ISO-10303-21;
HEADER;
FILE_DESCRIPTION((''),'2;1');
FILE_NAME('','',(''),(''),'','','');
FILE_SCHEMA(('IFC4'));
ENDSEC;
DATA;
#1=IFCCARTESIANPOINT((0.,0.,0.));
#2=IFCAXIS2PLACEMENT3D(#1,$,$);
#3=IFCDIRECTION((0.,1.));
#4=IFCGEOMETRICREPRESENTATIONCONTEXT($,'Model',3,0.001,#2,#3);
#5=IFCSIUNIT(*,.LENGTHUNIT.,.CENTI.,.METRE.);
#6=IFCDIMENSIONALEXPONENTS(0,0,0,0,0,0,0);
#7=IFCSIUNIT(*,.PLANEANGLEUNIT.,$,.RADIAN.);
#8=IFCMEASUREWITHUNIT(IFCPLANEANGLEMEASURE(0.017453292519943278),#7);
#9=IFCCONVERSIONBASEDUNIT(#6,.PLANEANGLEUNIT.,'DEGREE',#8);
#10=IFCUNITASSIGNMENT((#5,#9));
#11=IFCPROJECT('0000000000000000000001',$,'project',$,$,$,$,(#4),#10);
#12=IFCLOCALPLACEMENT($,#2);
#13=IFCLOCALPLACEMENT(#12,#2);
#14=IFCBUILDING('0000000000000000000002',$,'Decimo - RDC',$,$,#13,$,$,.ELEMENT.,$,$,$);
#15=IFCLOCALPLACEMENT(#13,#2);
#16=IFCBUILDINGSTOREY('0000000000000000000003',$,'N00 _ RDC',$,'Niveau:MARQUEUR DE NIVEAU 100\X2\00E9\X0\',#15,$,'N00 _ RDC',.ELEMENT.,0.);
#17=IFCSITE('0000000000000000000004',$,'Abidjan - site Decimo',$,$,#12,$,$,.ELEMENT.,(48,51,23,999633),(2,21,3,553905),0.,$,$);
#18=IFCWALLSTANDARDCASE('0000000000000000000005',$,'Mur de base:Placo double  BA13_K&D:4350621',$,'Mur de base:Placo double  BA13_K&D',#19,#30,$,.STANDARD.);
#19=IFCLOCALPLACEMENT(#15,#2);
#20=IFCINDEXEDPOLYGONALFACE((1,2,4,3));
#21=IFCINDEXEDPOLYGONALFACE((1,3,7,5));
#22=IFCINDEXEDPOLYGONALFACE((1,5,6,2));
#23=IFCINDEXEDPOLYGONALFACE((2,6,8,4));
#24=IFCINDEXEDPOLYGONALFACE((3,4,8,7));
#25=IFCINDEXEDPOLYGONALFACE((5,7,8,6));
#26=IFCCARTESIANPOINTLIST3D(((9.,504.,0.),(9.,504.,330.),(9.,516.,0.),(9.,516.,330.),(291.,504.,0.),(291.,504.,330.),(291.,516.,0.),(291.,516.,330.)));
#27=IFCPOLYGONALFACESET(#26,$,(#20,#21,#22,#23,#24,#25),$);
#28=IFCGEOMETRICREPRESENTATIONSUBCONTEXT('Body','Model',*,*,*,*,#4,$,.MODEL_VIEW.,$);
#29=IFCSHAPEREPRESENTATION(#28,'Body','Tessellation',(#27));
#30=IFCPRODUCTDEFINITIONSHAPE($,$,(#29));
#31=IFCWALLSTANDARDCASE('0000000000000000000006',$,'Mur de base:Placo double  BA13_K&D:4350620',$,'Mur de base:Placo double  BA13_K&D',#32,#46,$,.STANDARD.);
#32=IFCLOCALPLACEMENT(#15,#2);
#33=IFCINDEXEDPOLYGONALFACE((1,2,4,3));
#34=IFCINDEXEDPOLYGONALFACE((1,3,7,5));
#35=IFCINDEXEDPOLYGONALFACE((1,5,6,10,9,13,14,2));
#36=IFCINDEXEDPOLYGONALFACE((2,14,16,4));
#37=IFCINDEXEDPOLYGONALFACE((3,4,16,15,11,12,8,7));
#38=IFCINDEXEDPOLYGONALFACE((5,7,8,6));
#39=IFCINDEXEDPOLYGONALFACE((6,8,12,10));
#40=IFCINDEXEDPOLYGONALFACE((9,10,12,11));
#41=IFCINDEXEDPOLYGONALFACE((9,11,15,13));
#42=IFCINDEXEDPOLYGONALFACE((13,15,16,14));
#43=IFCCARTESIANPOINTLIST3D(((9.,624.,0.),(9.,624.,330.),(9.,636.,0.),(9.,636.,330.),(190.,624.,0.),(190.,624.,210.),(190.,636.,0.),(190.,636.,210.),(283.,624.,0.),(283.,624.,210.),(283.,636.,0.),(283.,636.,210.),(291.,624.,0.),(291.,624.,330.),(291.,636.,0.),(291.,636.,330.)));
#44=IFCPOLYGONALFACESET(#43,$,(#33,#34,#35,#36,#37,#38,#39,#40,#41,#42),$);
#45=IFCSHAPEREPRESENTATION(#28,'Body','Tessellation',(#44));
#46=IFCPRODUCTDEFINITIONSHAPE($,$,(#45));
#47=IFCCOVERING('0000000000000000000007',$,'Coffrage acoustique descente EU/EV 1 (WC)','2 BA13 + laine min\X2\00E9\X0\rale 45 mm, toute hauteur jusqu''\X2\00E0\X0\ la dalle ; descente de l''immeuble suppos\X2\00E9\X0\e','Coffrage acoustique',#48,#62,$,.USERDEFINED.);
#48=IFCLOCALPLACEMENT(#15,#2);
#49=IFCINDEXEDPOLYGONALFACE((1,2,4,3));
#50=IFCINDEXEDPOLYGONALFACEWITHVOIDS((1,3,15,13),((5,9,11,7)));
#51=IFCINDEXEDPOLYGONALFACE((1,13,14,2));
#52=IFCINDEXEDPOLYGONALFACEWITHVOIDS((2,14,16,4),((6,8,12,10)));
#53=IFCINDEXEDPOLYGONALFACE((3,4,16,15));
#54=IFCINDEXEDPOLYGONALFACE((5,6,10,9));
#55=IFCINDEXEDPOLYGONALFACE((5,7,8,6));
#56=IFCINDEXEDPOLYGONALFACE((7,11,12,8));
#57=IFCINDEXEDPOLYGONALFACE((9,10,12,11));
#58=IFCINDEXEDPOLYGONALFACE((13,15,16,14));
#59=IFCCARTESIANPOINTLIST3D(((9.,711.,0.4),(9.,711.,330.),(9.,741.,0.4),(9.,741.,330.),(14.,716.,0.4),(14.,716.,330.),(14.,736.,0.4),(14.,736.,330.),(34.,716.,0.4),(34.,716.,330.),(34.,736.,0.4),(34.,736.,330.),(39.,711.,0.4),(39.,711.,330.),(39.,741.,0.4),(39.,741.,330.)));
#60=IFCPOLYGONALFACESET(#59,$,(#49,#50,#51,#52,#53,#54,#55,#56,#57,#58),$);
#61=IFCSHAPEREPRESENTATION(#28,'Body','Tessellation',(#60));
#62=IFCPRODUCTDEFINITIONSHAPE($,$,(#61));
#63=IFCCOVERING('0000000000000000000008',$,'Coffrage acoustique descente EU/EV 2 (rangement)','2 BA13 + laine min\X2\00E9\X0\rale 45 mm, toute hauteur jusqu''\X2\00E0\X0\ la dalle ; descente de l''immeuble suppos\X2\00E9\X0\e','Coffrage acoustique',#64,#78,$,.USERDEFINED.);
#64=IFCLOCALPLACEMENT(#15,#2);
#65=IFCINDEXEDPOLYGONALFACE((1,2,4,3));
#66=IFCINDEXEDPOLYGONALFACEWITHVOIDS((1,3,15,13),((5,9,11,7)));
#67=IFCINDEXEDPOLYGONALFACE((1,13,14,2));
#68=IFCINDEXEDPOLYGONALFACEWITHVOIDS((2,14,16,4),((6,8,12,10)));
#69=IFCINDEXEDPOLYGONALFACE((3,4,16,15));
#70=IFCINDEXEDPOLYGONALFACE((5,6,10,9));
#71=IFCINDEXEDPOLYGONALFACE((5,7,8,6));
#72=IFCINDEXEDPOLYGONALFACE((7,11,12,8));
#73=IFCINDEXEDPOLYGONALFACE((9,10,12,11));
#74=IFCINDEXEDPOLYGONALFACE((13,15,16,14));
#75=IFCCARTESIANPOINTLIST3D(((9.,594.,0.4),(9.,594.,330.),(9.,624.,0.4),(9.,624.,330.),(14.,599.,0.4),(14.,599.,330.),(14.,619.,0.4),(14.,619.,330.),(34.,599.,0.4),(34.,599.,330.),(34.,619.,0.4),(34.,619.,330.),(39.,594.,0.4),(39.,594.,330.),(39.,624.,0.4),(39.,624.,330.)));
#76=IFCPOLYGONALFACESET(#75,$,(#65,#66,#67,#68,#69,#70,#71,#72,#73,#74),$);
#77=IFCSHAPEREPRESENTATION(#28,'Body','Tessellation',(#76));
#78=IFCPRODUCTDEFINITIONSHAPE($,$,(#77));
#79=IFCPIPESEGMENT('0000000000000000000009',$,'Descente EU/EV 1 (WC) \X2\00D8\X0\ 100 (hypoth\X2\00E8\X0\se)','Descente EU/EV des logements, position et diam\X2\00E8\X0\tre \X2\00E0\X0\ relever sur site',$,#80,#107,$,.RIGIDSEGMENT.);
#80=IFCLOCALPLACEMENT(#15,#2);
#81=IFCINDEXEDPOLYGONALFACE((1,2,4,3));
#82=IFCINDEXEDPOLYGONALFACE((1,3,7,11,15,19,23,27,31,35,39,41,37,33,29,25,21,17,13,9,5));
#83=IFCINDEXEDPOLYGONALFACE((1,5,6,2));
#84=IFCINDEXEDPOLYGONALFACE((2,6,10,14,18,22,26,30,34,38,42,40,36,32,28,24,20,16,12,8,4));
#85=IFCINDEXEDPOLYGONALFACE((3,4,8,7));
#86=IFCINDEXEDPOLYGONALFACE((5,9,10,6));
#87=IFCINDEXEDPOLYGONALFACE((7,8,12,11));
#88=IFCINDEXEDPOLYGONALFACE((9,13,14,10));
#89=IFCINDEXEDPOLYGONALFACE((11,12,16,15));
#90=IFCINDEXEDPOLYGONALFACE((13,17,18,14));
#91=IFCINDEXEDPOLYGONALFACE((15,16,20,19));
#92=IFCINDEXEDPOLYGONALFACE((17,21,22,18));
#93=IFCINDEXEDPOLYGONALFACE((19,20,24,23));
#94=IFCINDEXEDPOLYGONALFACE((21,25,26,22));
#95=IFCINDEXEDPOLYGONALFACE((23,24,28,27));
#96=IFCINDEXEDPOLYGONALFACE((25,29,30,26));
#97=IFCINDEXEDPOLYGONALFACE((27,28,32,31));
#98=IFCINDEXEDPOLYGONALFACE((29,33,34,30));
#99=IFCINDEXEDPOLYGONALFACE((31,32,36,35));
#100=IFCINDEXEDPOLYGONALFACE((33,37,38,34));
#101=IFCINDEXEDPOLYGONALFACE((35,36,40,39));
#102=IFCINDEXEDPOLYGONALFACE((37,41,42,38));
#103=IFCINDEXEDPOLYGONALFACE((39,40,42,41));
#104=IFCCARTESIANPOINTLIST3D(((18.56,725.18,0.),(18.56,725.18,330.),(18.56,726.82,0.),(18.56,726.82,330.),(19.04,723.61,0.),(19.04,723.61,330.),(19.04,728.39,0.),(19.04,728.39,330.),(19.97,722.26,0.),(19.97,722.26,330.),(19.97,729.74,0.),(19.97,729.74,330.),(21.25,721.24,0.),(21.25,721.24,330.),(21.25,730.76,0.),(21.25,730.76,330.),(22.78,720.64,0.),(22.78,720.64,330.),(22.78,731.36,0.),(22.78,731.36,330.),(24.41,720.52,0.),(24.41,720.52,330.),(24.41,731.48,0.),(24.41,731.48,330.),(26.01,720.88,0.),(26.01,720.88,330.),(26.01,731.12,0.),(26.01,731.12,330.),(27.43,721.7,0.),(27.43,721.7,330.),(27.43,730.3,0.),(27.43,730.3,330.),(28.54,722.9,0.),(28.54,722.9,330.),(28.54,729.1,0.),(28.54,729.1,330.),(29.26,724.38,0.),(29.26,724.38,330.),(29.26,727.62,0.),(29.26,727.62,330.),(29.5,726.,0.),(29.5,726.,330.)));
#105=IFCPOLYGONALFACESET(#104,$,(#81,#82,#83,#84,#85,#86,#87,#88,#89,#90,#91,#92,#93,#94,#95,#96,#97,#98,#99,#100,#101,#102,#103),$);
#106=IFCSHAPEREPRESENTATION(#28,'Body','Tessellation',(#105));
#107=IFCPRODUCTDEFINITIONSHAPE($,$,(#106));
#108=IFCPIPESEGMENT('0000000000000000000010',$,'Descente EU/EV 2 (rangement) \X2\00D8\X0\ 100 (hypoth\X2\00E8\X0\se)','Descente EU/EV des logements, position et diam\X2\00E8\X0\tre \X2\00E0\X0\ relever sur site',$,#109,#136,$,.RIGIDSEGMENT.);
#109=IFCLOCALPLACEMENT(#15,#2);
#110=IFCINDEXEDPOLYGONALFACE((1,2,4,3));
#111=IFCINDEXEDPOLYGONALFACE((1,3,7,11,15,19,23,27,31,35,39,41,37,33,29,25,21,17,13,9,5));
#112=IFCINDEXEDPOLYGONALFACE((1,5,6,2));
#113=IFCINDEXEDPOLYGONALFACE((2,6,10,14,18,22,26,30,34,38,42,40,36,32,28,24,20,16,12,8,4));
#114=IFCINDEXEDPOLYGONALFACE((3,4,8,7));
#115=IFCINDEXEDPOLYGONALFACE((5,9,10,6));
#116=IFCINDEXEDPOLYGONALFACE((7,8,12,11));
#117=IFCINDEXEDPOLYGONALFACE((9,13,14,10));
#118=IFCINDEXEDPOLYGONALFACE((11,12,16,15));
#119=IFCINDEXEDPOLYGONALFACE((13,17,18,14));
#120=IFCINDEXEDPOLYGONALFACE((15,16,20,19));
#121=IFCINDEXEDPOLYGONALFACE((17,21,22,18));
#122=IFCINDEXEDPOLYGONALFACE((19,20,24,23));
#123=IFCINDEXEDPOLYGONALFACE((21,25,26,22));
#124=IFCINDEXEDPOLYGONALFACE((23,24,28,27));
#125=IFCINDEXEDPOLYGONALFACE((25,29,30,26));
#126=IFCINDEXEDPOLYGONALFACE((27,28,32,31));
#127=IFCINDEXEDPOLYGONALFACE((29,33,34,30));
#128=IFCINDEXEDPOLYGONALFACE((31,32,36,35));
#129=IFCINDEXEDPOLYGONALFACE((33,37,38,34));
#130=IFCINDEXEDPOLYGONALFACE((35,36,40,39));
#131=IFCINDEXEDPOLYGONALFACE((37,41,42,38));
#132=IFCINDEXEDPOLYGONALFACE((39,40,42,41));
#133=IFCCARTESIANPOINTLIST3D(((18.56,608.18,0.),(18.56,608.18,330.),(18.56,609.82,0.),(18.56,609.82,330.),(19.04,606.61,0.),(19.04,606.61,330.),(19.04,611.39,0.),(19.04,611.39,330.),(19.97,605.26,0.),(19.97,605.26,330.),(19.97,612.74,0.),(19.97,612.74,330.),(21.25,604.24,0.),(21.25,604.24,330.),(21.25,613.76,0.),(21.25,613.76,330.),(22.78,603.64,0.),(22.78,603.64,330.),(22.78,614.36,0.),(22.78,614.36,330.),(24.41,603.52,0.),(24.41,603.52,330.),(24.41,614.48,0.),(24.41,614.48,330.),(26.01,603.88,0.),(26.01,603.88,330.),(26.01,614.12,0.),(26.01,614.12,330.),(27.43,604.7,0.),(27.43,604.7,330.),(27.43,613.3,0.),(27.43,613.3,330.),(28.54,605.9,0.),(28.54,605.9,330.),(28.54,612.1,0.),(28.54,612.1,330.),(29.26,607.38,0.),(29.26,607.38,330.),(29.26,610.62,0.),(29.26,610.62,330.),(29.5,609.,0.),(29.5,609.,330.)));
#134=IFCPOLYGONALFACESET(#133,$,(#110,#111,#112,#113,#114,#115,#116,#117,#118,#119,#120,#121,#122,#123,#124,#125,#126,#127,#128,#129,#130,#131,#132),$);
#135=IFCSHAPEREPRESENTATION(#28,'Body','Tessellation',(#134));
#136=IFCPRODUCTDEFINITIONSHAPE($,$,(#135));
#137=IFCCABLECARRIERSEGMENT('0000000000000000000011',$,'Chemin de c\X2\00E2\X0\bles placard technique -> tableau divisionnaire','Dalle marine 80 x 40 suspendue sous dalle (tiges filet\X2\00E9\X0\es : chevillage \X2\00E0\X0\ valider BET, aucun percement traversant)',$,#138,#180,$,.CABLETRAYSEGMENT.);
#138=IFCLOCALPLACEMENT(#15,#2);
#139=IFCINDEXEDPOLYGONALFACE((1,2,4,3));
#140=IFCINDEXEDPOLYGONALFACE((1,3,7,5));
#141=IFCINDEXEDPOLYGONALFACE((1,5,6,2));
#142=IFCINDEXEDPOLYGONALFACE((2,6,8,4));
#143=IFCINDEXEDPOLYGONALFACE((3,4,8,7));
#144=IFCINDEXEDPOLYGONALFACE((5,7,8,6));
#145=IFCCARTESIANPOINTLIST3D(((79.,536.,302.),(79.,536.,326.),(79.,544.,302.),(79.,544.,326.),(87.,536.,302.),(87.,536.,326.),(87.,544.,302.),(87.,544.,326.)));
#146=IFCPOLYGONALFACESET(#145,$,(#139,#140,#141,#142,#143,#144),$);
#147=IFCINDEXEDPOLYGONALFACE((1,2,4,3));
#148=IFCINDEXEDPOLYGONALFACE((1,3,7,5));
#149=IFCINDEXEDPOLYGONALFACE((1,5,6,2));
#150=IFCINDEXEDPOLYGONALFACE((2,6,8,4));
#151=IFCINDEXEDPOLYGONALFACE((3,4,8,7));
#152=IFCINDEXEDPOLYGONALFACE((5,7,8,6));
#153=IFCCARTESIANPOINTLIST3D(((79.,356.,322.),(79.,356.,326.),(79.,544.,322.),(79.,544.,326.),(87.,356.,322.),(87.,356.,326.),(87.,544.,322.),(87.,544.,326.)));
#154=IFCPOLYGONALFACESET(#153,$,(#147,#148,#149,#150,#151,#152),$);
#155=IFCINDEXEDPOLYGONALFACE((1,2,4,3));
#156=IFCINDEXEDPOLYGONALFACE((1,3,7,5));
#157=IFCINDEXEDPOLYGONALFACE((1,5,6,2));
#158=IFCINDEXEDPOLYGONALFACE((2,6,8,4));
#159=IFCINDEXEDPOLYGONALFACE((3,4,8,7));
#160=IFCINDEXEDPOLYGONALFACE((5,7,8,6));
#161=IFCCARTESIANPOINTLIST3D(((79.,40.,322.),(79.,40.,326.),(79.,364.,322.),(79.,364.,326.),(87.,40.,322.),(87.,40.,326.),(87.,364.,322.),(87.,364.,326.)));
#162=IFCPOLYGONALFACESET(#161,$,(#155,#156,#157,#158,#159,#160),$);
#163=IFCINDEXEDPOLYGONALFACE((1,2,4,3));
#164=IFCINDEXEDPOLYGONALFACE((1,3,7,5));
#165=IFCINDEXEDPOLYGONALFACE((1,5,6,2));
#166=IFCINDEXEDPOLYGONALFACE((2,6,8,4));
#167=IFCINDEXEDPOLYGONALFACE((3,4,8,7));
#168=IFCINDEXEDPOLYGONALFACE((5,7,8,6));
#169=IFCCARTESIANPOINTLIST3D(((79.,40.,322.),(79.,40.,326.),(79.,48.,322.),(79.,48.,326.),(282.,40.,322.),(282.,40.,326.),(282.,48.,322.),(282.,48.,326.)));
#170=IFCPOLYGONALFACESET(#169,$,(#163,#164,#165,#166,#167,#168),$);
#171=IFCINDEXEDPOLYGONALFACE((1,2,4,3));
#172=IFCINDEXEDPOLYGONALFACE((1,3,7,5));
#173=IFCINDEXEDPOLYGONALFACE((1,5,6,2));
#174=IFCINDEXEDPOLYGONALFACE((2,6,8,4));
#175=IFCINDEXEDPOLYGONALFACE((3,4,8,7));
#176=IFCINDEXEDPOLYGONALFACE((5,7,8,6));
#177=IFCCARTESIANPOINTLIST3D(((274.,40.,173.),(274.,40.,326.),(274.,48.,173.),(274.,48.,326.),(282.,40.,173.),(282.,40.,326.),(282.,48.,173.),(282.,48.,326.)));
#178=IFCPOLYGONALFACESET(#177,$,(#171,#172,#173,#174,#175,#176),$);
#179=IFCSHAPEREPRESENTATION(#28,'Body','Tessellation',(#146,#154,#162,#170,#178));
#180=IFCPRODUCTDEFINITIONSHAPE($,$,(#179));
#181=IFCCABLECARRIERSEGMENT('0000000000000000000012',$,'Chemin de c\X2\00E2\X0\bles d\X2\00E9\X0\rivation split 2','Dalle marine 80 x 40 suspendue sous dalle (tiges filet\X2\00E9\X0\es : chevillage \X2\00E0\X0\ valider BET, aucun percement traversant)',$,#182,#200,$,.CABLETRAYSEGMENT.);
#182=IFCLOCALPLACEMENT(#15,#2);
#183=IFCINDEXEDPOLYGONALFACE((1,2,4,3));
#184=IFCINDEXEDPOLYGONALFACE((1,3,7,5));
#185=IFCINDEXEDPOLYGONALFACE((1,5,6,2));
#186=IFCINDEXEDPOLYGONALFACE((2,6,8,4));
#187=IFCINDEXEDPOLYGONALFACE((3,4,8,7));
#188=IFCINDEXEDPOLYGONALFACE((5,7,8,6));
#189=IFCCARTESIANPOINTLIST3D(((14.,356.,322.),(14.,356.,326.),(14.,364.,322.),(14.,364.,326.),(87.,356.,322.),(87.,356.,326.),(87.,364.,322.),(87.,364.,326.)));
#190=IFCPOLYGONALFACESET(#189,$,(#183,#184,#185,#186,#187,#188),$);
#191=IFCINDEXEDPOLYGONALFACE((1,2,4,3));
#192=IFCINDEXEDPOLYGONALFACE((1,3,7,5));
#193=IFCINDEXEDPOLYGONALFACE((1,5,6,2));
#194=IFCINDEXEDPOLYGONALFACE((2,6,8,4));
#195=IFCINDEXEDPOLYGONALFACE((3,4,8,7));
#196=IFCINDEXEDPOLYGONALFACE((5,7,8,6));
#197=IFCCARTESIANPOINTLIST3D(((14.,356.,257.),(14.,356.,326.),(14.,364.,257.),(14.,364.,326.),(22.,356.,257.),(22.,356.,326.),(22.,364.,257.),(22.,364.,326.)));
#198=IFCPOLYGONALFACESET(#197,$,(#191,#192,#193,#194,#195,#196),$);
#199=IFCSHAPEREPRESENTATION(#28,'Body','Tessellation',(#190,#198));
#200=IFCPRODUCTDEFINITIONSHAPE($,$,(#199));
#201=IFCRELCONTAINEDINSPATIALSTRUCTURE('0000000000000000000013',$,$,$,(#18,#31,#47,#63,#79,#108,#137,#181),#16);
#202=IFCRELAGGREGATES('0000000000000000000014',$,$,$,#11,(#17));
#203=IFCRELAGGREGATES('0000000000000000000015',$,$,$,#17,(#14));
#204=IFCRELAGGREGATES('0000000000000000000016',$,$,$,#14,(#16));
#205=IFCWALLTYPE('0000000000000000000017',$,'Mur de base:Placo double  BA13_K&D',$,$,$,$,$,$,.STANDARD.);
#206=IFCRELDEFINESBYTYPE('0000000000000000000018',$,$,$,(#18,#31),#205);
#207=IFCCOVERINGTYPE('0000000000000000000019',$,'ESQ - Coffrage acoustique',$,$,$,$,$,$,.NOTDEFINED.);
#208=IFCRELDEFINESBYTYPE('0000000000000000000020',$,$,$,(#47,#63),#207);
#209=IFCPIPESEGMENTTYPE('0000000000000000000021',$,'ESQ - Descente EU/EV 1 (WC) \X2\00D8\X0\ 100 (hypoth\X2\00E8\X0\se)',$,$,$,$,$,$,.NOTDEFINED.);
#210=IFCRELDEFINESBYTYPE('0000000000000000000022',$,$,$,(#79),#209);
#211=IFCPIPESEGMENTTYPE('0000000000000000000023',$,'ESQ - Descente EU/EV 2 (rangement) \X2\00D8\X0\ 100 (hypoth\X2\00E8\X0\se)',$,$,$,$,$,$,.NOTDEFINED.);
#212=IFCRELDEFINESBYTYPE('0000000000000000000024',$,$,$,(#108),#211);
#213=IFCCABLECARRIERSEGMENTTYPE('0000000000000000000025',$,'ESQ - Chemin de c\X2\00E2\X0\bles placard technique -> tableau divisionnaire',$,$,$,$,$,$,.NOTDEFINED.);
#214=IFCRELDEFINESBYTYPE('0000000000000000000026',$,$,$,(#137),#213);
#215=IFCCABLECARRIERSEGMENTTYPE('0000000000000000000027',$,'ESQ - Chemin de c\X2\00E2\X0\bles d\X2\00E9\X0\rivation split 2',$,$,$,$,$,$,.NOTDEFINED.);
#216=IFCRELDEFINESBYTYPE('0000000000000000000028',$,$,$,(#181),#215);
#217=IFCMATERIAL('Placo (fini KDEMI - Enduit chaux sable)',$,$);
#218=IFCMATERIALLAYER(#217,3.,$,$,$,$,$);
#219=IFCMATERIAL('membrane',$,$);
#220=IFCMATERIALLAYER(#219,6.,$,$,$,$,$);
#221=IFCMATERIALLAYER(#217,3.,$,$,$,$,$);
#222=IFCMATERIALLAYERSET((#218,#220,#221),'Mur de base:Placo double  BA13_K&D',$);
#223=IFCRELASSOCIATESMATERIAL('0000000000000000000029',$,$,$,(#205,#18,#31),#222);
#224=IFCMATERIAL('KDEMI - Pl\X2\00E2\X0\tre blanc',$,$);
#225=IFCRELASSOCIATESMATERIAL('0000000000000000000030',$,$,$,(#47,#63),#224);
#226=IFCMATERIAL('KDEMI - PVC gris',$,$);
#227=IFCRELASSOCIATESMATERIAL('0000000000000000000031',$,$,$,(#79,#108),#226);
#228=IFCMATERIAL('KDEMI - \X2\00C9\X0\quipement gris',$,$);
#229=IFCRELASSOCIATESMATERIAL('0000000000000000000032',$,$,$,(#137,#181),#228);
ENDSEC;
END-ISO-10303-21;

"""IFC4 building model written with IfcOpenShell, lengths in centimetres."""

from ifc_helpers import new_model, entity, si_unit, converted_unit, direction, frame, frame_2d, origin, origin_with_axes, place, context, subcontext, project, spatial, rectangle, hollow_rectangle, circle, extrude, material, layer, layer_set, layer_usage, type_object, element, save


model = new_model("IFC4")

# Units and contexts
model_context = context("Model", 3, precision=0.001, world=origin(), true_north=direction((0.0, 1.0)))
body_context = subcontext(model_context, "Body", "Model", "MODEL_VIEW")
ifc_project = project(units=[si_unit("LENGTHUNIT", "METRE", prefix="CENTI"), converted_unit("PLANEANGLEUNIT", "DEGREE", entity("IfcPlaneAngleMeasure", 0.017453292519943278), si_unit("PLANEANGLEUNIT", "RADIAN"), dimensions=[0, 0, 0, 0, 0, 0, 0])], contexts=[model_context])

# Site, building, storey
site_placement = place(None, origin())
site = spatial("IfcSite", under=ifc_project, at=site_placement, Name="Abidjan - site Decimo", CompositionType="ELEMENT", RefLatitude=(48, 51, 23, 999633), RefLongitude=(2, 21, 3, 553905), RefElevation=0.0)
building_placement = place(site_placement, origin())
building = spatial("IfcBuilding", under=site, at=building_placement, Name="Decimo - RDC", CompositionType="ELEMENT")
storey_placement = place(building_placement, origin())
storey = spatial("IfcBuildingStorey", under=building, at=storey_placement, Name="N00 _ RDC", ObjectType="Niveau:MARQUEUR DE NIVEAU 100é", LongName="N00 _ RDC", CompositionType="ELEMENT", Elevation=0.0)

# Wall
ifc_material_1 = material(Name="Placo (fini KDEMI - Enduit chaux sable)")
ifc_layer_1 = layer(ifc_material_1, 3.0)
ifc_material_2 = material(Name="membrane")
ifc_layer_2 = layer(ifc_material_2, 6.0)
ifc_layer_3 = layer(ifc_material_1, 3.0)
ifc_layer_set_1 = layer_set([ifc_layer_1, ifc_layer_2, ifc_layer_3], Name="Mur de base:Placo double  BA13_K&D")
ifc_layer_usage_1 = layer_usage(ifc_layer_set_1, "AXIS2", "POSITIVE", -6.0)
wall_type_1 = type_object("IfcWallType", Name="Mur de base:Placo double  BA13_K&D", PredefinedType="STANDARD", material=ifc_layer_set_1)
wall_1_placement = place(storey_placement, frame((9.0, 510.0, 0.0)))
element("IfcWallStandardCase", 1, at=wall_1_placement, inside=storey, type_object=wall_type_1, material=ifc_layer_usage_1, Name="Mur de base:Placo double  BA13_K&D:4350621", ObjectType="Mur de base:Placo double  BA13_K&D", PredefinedType="STANDARD", context=body_context, shape_type="SweptSolid", body=[
    extrude(rectangle(XDim=282.0, YDim=12.0, at=frame_2d((141.0, 0.0), x_axis=(-1.0, 0.0))), origin(), (0.0, 0.0, 1.0), 330.0),
])

# Wall, opening
ifc_layer_usage_2 = layer_usage(ifc_layer_set_1, "AXIS2", "NEGATIVE", 6.0)
wall_2_placement = place(storey_placement, frame((9.0, 630.0, 0.0)))
wall_2 = element("IfcWallStandardCase", 2, at=wall_2_placement, inside=storey, type_object=wall_type_1, material=ifc_layer_usage_2, Name="Mur de base:Placo double  BA13_K&D:4350620", ObjectType="Mur de base:Placo double  BA13_K&D", PredefinedType="STANDARD", context=body_context, shape_type="SweptSolid", body=[
    extrude(rectangle(XDim=282.0, YDim=12.0, at=frame_2d((141.0, 0.0), x_axis=(-1.0, 0.0))), origin(), (0.0, 0.0, 1.0), 330.0),
])
opening_1_placement = place(wall_2_placement, frame((-9.0, -630.0, 0.0), z_axis=(0.0, 0.0, 1.0), x_axis=(1.0, 0.0, 0.0)))
element("IfcOpeningElement", 3, at=opening_1_placement, inside=storey, cuts=wall_2, context=body_context, shape_type="SweptSolid", body=[
    extrude(rectangle(XDim=93.0, YDim=16.0, at=frame_2d((236.5, 630.0))), origin(), (0.0, 0.0, 1.0), 210.0),
])

# Coverings
ifc_material_3 = material(Name="KDEMI - Plâtre blanc")
covering_type = type_object("IfcCoveringType", Name="ESQ - Coffrage acoustique", PredefinedType="NOTDEFINED")
covering_1_placement = place(storey_placement, origin_with_axes())
element("IfcCovering", 4, at=covering_1_placement, inside=storey, type_object=covering_type, material=ifc_material_3, Name="Coffrage acoustique descente EU/EV 1 (WC)", Description="2 BA13 + laine minérale 45 mm, toute hauteur jusqu'à la dalle ; descente de l'immeuble supposée", ObjectType="Coffrage acoustique", PredefinedType="USERDEFINED", context=body_context, shape_type="SweptSolid", body=[
    extrude(hollow_rectangle(XDim=30.0, YDim=30.0, WallThickness=5.0, at=frame_2d((24.0, 726.0))), frame((0.0, 0.0, 0.4)), (0.0, 0.0, 1.0), 329.6),
])
covering_2_placement = place(storey_placement, origin_with_axes())
element("IfcCovering", 5, at=covering_2_placement, inside=storey, type_object=covering_type, material=ifc_material_3, Name="Coffrage acoustique descente EU/EV 2 (rangement)", Description="2 BA13 + laine minérale 45 mm, toute hauteur jusqu'à la dalle ; descente de l'immeuble supposée", ObjectType="Coffrage acoustique", PredefinedType="USERDEFINED", context=body_context, shape_type="SweptSolid", body=[
    extrude(hollow_rectangle(XDim=30.0, YDim=30.0, WallThickness=5.0, at=frame_2d((24.0, 609.0))), frame((0.0, 0.0, 0.4)), (0.0, 0.0, 1.0), 329.6),
])

# Pipe segments
ifc_material_4 = material(Name="KDEMI - PVC gris")
pipe_segment_type_1 = type_object("IfcPipeSegmentType", Name="ESQ - Descente EU/EV 1 (WC) Ø 100 (hypothèse)", PredefinedType="NOTDEFINED")
pipe_segment_1_placement = place(storey_placement, origin_with_axes())
element("IfcPipeSegment", 6, at=pipe_segment_1_placement, inside=storey, type_object=pipe_segment_type_1, material=ifc_material_4, Name="Descente EU/EV 1 (WC) Ø 100 (hypothèse)", Description="Descente EU/EV des logements, position et diamètre à relever sur site", PredefinedType="RIGIDSEGMENT", context=body_context, shape_type="SweptSolid", body=[
    extrude(circle(Radius=5.5, at=frame_2d((24.0, 726.0))), origin(), (0.0, 0.0, 1.0), 330.0),
])
pipe_segment_type_2 = type_object("IfcPipeSegmentType", Name="ESQ - Descente EU/EV 2 (rangement) Ø 100 (hypothèse)", PredefinedType="NOTDEFINED")
pipe_segment_2_placement = place(storey_placement, origin_with_axes())
element("IfcPipeSegment", 7, at=pipe_segment_2_placement, inside=storey, type_object=pipe_segment_type_2, material=ifc_material_4, Name="Descente EU/EV 2 (rangement) Ø 100 (hypothèse)", Description="Descente EU/EV des logements, position et diamètre à relever sur site", PredefinedType="RIGIDSEGMENT", context=body_context, shape_type="SweptSolid", body=[
    extrude(circle(Radius=5.5, at=frame_2d((24.0, 609.0))), origin(), (0.0, 0.0, 1.0), 330.0),
])

# Cable carrier segments
ifc_material_5 = material(Name="KDEMI - Équipement gris")
cable_carrier_segment_type_1 = type_object("IfcCableCarrierSegmentType", Name="ESQ - Chemin de câbles placard technique -> tableau divisionnaire", PredefinedType="NOTDEFINED")
cable_carrier_segment_1_placement = place(storey_placement, origin_with_axes())
element("IfcCableCarrierSegment", 8, at=cable_carrier_segment_1_placement, inside=storey, type_object=cable_carrier_segment_type_1, material=ifc_material_5, Name="Chemin de câbles placard technique -> tableau divisionnaire", Description="Dalle marine 80 x 40 suspendue sous dalle (tiges filetées : chevillage à valider BET, aucun percement traversant)", PredefinedType="CABLETRAYSEGMENT", context=body_context, shape_type="SweptSolid", body=[
    extrude(rectangle(XDim=8.0, YDim=8.0, at=frame_2d((83.0, 540.0))), frame((0.0, 0.0, 302.0)), (0.0, 0.0, 1.0), 24.0),
    extrude(rectangle(XDim=8.0, YDim=188.0, at=frame_2d((83.0, 450.0))), frame((0.0, 0.0, 322.0)), (0.0, 0.0, 1.0), 4.0),
    extrude(rectangle(XDim=8.0, YDim=324.0, at=frame_2d((83.0, 202.0))), frame((0.0, 0.0, 322.0)), (0.0, 0.0, 1.0), 4.0),
    extrude(rectangle(XDim=203.0, YDim=8.0, at=frame_2d((180.5, 44.0))), frame((0.0, 0.0, 322.0)), (0.0, 0.0, 1.0), 4.0),
    extrude(rectangle(XDim=8.0, YDim=8.0, at=frame_2d((278.0, 44.0))), frame((0.0, 0.0, 173.0)), (0.0, 0.0, 1.0), 153.0),
])
cable_carrier_segment_type_2 = type_object("IfcCableCarrierSegmentType", Name="ESQ - Chemin de câbles dérivation split 2", PredefinedType="NOTDEFINED")
cable_carrier_segment_2_placement = place(storey_placement, origin_with_axes())
element("IfcCableCarrierSegment", 9, at=cable_carrier_segment_2_placement, inside=storey, type_object=cable_carrier_segment_type_2, material=ifc_material_5, Name="Chemin de câbles dérivation split 2", Description="Dalle marine 80 x 40 suspendue sous dalle (tiges filetées : chevillage à valider BET, aucun percement traversant)", PredefinedType="CABLETRAYSEGMENT", context=body_context, shape_type="SweptSolid", body=[
    extrude(rectangle(XDim=73.0, YDim=8.0, at=frame_2d((50.5, 360.0))), frame((0.0, 0.0, 322.0)), (0.0, 0.0, 1.0), 4.0),
    extrude(rectangle(XDim=8.0, YDim=8.0, at=frame_2d((18.0, 360.0))), frame((0.0, 0.0, 257.0)), (0.0, 0.0, 1.0), 69.0),
])

save(model, "model.ifc")
